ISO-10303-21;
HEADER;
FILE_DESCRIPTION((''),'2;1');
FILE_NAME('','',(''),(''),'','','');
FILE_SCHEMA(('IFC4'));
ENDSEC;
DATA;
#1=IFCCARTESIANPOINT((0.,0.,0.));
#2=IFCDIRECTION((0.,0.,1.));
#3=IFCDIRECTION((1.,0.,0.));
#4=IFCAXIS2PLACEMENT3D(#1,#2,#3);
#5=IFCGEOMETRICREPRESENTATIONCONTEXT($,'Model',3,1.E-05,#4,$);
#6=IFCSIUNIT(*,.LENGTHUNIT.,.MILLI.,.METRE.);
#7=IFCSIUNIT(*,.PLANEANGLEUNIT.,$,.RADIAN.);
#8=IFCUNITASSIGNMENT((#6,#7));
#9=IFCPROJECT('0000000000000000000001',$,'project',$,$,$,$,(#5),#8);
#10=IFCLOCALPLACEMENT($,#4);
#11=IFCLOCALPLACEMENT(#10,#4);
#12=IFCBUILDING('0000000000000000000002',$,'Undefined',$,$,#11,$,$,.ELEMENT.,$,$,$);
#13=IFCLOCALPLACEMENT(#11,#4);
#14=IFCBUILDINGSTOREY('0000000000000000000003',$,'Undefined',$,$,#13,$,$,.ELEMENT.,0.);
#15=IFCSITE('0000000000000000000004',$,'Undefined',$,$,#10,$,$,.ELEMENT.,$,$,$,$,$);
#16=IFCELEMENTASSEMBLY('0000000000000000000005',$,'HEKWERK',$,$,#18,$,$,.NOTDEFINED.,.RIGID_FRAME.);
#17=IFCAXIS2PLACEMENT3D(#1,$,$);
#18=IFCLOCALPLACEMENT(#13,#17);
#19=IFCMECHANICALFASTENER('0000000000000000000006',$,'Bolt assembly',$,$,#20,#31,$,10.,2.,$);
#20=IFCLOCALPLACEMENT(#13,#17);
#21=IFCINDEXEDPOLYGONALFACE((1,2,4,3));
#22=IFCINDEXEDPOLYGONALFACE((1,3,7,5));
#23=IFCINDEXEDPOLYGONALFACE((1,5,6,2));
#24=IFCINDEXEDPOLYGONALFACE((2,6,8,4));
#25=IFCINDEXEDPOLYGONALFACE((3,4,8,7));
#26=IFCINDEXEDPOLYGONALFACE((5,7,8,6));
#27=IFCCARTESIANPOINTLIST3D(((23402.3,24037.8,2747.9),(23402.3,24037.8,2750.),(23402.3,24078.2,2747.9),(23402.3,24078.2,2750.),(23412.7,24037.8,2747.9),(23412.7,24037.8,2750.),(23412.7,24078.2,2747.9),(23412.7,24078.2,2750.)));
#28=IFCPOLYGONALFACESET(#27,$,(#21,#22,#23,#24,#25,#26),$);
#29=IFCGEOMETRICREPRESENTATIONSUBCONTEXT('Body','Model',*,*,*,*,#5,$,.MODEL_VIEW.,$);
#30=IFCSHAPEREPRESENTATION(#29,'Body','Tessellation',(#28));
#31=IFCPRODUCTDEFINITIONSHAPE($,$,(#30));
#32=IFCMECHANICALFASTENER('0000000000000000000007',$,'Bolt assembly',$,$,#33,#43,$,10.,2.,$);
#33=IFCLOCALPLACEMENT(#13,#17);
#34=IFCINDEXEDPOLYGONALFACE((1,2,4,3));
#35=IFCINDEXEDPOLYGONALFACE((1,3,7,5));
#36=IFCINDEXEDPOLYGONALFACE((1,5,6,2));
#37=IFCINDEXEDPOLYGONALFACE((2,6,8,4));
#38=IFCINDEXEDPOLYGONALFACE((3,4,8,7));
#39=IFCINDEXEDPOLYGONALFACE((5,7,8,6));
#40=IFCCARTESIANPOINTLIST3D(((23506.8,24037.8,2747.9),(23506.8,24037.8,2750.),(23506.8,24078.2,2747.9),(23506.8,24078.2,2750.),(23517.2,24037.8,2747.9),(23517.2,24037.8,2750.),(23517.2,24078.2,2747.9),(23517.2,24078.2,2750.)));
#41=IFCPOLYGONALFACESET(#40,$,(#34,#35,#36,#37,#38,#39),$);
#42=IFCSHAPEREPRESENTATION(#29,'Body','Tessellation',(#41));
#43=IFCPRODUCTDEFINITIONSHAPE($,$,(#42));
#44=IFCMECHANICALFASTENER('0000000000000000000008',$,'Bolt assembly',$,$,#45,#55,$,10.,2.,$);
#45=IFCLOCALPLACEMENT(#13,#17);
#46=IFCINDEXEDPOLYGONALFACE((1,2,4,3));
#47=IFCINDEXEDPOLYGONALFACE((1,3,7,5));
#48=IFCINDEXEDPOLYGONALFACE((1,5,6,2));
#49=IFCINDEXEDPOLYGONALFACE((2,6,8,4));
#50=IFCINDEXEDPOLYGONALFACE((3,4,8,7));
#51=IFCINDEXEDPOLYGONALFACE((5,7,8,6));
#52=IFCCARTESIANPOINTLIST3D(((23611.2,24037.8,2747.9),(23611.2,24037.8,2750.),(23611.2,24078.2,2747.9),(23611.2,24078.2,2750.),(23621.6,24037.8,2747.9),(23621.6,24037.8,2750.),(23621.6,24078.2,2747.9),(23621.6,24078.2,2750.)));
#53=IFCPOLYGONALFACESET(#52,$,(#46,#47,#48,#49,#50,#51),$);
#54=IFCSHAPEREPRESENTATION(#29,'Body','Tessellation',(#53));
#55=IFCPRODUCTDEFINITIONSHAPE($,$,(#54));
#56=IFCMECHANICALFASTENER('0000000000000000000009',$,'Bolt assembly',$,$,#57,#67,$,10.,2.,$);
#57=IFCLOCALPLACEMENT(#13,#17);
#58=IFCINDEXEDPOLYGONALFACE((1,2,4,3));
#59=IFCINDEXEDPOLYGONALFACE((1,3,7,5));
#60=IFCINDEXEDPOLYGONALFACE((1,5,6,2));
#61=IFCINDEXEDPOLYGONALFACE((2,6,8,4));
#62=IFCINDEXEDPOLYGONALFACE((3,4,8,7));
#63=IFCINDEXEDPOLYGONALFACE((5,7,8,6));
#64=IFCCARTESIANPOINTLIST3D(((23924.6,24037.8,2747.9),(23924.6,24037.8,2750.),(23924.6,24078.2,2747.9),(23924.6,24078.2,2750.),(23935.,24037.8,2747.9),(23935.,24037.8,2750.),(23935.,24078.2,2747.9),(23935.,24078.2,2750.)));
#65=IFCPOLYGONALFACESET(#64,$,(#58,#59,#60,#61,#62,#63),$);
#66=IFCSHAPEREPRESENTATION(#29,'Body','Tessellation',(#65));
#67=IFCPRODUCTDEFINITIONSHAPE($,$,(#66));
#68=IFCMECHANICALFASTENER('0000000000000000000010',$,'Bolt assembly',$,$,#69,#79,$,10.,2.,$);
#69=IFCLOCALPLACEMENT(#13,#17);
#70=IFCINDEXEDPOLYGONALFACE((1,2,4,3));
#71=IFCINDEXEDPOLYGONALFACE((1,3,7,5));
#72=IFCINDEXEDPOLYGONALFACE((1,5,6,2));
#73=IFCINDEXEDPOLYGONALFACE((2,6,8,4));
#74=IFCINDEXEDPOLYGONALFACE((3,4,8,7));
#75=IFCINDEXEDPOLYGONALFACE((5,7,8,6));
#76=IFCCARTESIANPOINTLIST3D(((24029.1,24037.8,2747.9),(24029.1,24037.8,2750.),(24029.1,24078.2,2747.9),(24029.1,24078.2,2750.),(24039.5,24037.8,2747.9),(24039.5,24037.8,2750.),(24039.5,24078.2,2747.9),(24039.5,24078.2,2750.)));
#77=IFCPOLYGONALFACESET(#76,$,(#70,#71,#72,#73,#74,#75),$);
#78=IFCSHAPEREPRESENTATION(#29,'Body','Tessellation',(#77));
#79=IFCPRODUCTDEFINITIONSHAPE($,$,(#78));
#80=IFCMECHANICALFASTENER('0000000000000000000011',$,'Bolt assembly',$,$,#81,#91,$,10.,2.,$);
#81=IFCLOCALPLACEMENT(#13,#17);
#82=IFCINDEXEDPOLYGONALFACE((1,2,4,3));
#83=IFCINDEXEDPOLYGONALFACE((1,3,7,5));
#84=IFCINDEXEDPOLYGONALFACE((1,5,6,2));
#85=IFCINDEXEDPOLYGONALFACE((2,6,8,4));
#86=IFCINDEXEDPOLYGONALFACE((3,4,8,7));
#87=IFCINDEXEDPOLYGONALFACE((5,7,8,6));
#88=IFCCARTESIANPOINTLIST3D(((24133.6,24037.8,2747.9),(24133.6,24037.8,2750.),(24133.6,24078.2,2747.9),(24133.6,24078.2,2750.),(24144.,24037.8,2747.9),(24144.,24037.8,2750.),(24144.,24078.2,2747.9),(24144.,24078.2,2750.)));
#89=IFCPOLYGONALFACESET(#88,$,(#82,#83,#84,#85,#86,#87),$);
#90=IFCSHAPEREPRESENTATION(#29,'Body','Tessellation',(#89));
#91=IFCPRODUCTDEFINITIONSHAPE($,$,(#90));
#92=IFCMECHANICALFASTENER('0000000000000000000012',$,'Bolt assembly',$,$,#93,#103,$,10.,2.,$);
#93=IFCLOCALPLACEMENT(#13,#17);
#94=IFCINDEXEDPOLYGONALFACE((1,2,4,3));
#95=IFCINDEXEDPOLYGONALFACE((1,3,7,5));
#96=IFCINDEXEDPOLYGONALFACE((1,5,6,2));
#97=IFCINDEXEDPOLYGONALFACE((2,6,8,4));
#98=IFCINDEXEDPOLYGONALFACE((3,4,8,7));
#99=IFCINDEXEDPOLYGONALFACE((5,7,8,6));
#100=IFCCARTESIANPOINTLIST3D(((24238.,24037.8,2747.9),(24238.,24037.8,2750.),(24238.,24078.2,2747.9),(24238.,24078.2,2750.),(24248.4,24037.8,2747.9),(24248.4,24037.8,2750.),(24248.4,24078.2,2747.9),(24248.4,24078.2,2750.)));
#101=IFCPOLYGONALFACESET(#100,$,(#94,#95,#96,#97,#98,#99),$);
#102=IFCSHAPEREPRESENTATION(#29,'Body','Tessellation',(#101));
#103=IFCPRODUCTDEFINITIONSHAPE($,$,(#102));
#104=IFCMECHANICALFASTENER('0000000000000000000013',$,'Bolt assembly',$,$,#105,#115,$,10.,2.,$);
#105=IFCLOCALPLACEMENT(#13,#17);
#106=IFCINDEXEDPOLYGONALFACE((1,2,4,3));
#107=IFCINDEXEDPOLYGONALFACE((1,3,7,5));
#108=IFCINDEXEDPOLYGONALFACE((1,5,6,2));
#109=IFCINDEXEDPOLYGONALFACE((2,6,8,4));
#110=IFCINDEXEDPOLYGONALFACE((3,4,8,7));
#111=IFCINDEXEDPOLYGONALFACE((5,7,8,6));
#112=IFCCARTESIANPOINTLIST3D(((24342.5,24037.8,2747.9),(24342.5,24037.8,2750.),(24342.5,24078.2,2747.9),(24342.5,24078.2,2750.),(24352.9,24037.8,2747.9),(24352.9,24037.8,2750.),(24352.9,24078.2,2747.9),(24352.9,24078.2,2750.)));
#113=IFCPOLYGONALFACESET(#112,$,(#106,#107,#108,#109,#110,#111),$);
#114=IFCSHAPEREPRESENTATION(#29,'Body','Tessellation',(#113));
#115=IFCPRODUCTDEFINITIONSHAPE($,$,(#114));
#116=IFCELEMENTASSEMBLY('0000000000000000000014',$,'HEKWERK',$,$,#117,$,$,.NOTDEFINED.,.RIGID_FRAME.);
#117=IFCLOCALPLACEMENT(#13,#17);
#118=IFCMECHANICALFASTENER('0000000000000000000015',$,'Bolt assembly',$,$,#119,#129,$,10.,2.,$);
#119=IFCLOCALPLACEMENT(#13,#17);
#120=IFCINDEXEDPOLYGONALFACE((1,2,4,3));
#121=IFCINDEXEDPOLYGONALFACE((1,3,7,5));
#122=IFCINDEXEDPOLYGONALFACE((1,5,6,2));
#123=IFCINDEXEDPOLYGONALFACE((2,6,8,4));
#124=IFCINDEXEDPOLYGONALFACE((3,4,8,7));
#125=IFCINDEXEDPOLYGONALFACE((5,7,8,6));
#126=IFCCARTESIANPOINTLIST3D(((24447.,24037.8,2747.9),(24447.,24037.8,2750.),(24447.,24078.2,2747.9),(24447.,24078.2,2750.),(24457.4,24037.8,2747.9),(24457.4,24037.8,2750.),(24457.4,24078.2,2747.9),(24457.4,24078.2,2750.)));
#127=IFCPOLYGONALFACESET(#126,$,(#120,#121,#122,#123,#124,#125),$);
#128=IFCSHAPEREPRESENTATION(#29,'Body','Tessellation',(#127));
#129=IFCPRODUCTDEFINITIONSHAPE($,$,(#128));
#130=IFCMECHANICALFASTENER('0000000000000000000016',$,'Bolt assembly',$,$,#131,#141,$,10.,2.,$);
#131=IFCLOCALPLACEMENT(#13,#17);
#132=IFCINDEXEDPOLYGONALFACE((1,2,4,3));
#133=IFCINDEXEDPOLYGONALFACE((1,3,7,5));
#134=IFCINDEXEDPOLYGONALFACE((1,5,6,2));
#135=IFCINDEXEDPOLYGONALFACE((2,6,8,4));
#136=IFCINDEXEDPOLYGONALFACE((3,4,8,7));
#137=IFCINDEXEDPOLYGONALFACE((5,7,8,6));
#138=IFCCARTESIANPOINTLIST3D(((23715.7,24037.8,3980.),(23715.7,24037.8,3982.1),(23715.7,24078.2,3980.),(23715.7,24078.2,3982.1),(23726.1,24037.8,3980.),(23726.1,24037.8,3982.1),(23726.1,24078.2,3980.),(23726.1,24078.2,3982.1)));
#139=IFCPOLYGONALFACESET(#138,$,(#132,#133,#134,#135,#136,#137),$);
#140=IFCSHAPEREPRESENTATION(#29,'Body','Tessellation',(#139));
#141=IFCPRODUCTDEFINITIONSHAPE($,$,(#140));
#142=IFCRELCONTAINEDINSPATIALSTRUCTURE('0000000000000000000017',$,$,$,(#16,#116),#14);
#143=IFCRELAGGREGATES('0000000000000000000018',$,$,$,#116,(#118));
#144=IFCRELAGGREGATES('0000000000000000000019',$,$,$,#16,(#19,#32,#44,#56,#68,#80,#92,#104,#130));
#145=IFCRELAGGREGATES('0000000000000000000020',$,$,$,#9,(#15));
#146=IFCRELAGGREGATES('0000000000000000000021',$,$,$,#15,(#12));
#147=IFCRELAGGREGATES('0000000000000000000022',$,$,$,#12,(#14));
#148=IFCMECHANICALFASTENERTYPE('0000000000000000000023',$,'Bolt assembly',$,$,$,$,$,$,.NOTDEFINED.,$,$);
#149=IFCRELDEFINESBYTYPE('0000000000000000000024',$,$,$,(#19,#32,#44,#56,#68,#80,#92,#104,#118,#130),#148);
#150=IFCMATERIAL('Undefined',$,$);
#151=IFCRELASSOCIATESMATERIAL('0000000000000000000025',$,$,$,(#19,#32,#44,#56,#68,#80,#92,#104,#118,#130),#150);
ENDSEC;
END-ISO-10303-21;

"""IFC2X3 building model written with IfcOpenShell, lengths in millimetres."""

from ifc_helpers import new_model, si_unit, frame, origin_with_axes, place, context, subcontext, project, spatial, polyline, segment, composite_curve, outline, extrude, source, transform, mapped, material, type_object, element, aggregate, save


model = new_model("IFC2X3")

# Units and contexts
model_context = context("Model", 3, precision=1e-05, world=origin_with_axes())
body_context = subcontext(model_context, "Body", "Model", "MODEL_VIEW")
ifc_project = project(units=[si_unit("LENGTHUNIT", "METRE", prefix="MILLI"), si_unit("PLANEANGLEUNIT", "RADIAN")], contexts=[model_context])

# Site, building, storey
site_placement = place(None, origin_with_axes())
site = spatial("IfcSite", under=ifc_project, at=site_placement, Name="Undefined", CompositionType="ELEMENT")
building_placement = place(site_placement, origin_with_axes())
building = spatial("IfcBuilding", under=site, at=building_placement, Name="Undefined", CompositionType="ELEMENT")
storey_placement = place(building_placement, origin_with_axes())
storey = spatial("IfcBuildingStorey", under=building, at=storey_placement, Name="Undefined", CompositionType="ELEMENT", Elevation=0.0)

# Element assembly, mechanical fasteners
assembly_1_placement = place(storey_placement, origin_with_axes())
assembly_1 = element("IfcElementAssembly", 1, at=assembly_1_placement, inside=storey, Name="HEKWERK", AssemblyPlace="NOTDEFINED", PredefinedType="RIGID_FRAME")
ifc_material_1 = material(Name="Undefined")
mechanical_fastener_type = type_object("IfcMechanicalFastenerType", Name="Bolt assembly")
shared_shape_1 = source(origin_with_axes(), body_context, "Body", "SweptSolid", [
    extrude(outline(composite_curve([segment(polyline([(-20.2, 5.2), (20.2, 5.2)]), True, "CONTINUOUS"), segment(polyline([(20.2, 5.2), (20.2, -5.2)]), True, "CONTINUOUS"), segment(polyline([(20.2, -5.2), (-20.2, -5.2)]), True, "CONTINUOUS"), segment(polyline([(-20.2, -5.2), (-20.2, 5.2)]), True, "CONTINUOUS")], self_intersect=False)), frame((0.0, -1.0, 0.0), z_axis=(0.0, 1.0, 0.0), x_axis=(1.0, 0.0, 0.0)), (0.0, 0.0, 1.0), 2.1),
])
mechanical_fastener_1_placement = place(assembly_1_placement, frame((23407.5, 24058.0, 2749.0), z_axis=(-1.0, 0.0, 0.0), x_axis=(0.0, 1.0, 0.0)))
mechanical_fastener_1 = element("IfcMechanicalFastener", 2, at=mechanical_fastener_1_placement, type_object=mechanical_fastener_type, material=ifc_material_1, Name="Bolt assembly", NominalDiameter=10.0, NominalLength=2.0, context=body_context, shape_type="MappedRepresentation", body=[
    mapped(shared_shape_1, transform((0.0, 0.0, 0.0))),
])
shared_shape_2 = source(origin_with_axes(), body_context, "Body", "SweptSolid", [
    extrude(outline(composite_curve([segment(polyline([(-20.2, 5.2), (20.2, 5.2)]), True, "CONTINUOUS"), segment(polyline([(20.2, 5.2), (20.2, -5.2)]), True, "CONTINUOUS"), segment(polyline([(20.2, -5.2), (-20.2, -5.2)]), True, "CONTINUOUS"), segment(polyline([(-20.2, -5.2), (-20.2, 5.2)]), True, "CONTINUOUS")], self_intersect=False)), frame((0.0, -1.0, 0.0), z_axis=(0.0, 1.0, 0.0), x_axis=(1.0, 0.0, 0.0)), (0.0, 0.0, 1.0), 2.1),
])
mechanical_fastener_2_placement = place(assembly_1_placement, frame((23512.0, 24058.0, 2749.0), z_axis=(-1.0, 0.0, 0.0), x_axis=(0.0, 1.0, 0.0)))
mechanical_fastener_2 = element("IfcMechanicalFastener", 3, at=mechanical_fastener_2_placement, type_object=mechanical_fastener_type, material=ifc_material_1, Name="Bolt assembly", NominalDiameter=10.0, NominalLength=2.0, context=body_context, shape_type="MappedRepresentation", body=[
    mapped(shared_shape_2, transform((0.0, 0.0, 0.0))),
])
shared_shape_3 = source(origin_with_axes(), body_context, "Body", "SweptSolid", [
    extrude(outline(composite_curve([segment(polyline([(-20.2, 5.2), (20.2, 5.2)]), True, "CONTINUOUS"), segment(polyline([(20.2, 5.2), (20.2, -5.2)]), True, "CONTINUOUS"), segment(polyline([(20.2, -5.2), (-20.2, -5.2)]), True, "CONTINUOUS"), segment(polyline([(-20.2, -5.2), (-20.2, 5.2)]), True, "CONTINUOUS")], self_intersect=False)), frame((0.0, -1.0, 0.0), z_axis=(0.0, 1.0, 0.0), x_axis=(1.0, 0.0, 0.0)), (0.0, 0.0, 1.0), 2.1),
])
mechanical_fastener_3_placement = place(assembly_1_placement, frame((23616.4, 24058.0, 2749.0), z_axis=(-1.0, 0.0, 0.0), x_axis=(0.0, 1.0, 0.0)))
mechanical_fastener_3 = element("IfcMechanicalFastener", 4, at=mechanical_fastener_3_placement, type_object=mechanical_fastener_type, material=ifc_material_1, Name="Bolt assembly", NominalDiameter=10.0, NominalLength=2.0, context=body_context, shape_type="MappedRepresentation", body=[
    mapped(shared_shape_3, transform((0.0, 0.0, 0.0))),
])
shared_shape_4 = source(origin_with_axes(), body_context, "Body", "SweptSolid", [
    extrude(outline(composite_curve([segment(polyline([(-20.2, 5.2), (20.2, 5.2)]), True, "CONTINUOUS"), segment(polyline([(20.2, 5.2), (20.2, -5.2)]), True, "CONTINUOUS"), segment(polyline([(20.2, -5.2), (-20.2, -5.2)]), True, "CONTINUOUS"), segment(polyline([(-20.2, -5.2), (-20.2, 5.2)]), True, "CONTINUOUS")], self_intersect=False)), frame((0.0, -1.0, 0.0), z_axis=(0.0, 1.0, 0.0), x_axis=(1.0, 0.0, 0.0)), (0.0, 0.0, 1.0), 2.1),
])
mechanical_fastener_4_placement = place(assembly_1_placement, frame((23929.8, 24058.0, 2749.0), z_axis=(-1.0, 0.0, 0.0), x_axis=(0.0, 1.0, 0.0)))
mechanical_fastener_4 = element("IfcMechanicalFastener", 5, at=mechanical_fastener_4_placement, type_object=mechanical_fastener_type, material=ifc_material_1, Name="Bolt assembly", NominalDiameter=10.0, NominalLength=2.0, context=body_context, shape_type="MappedRepresentation", body=[
    mapped(shared_shape_4, transform((0.0, 0.0, 0.0))),
])
shared_shape_5 = source(origin_with_axes(), body_context, "Body", "SweptSolid", [
    extrude(outline(composite_curve([segment(polyline([(-20.2, 5.2), (20.2, 5.2)]), True, "CONTINUOUS"), segment(polyline([(20.2, 5.2), (20.2, -5.2)]), True, "CONTINUOUS"), segment(polyline([(20.2, -5.2), (-20.2, -5.2)]), True, "CONTINUOUS"), segment(polyline([(-20.2, -5.2), (-20.2, 5.2)]), True, "CONTINUOUS")], self_intersect=False)), frame((0.0, -1.0, 0.0), z_axis=(0.0, 1.0, 0.0), x_axis=(1.0, 0.0, 0.0)), (0.0, 0.0, 1.0), 2.1),
])
mechanical_fastener_5_placement = place(assembly_1_placement, frame((24034.3, 24058.0, 2749.0), z_axis=(-1.0, 0.0, 0.0), x_axis=(0.0, 1.0, 0.0)))
mechanical_fastener_5 = element("IfcMechanicalFastener", 6, at=mechanical_fastener_5_placement, type_object=mechanical_fastener_type, material=ifc_material_1, Name="Bolt assembly", NominalDiameter=10.0, NominalLength=2.0, context=body_context, shape_type="MappedRepresentation", body=[
    mapped(shared_shape_5, transform((0.0, 0.0, 0.0))),
])
shared_shape_6 = source(origin_with_axes(), body_context, "Body", "SweptSolid", [
    extrude(outline(composite_curve([segment(polyline([(-20.2, 5.2), (20.2, 5.2)]), True, "CONTINUOUS"), segment(polyline([(20.2, 5.2), (20.2, -5.2)]), True, "CONTINUOUS"), segment(polyline([(20.2, -5.2), (-20.2, -5.2)]), True, "CONTINUOUS"), segment(polyline([(-20.2, -5.2), (-20.2, 5.2)]), True, "CONTINUOUS")], self_intersect=False)), frame((0.0, -1.0, 0.0), z_axis=(0.0, 1.0, 0.0), x_axis=(1.0, 0.0, 0.0)), (0.0, 0.0, 1.0), 2.1),
])
mechanical_fastener_6_placement = place(assembly_1_placement, frame((24138.8, 24058.0, 2749.0), z_axis=(-1.0, 0.0, 0.0), x_axis=(0.0, 1.0, 0.0)))
mechanical_fastener_6 = element("IfcMechanicalFastener", 7, at=mechanical_fastener_6_placement, type_object=mechanical_fastener_type, material=ifc_material_1, Name="Bolt assembly", NominalDiameter=10.0, NominalLength=2.0, context=body_context, shape_type="MappedRepresentation", body=[
    mapped(shared_shape_6, transform((0.0, 0.0, 0.0))),
])
shared_shape_7 = source(origin_with_axes(), body_context, "Body", "SweptSolid", [
    extrude(outline(composite_curve([segment(polyline([(-20.2, 5.2), (20.2, 5.2)]), True, "CONTINUOUS"), segment(polyline([(20.2, 5.2), (20.2, -5.2)]), True, "CONTINUOUS"), segment(polyline([(20.2, -5.2), (-20.2, -5.2)]), True, "CONTINUOUS"), segment(polyline([(-20.2, -5.2), (-20.2, 5.2)]), True, "CONTINUOUS")], self_intersect=False)), frame((0.0, -1.0, 0.0), z_axis=(0.0, 1.0, 0.0), x_axis=(1.0, 0.0, 0.0)), (0.0, 0.0, 1.0), 2.1),
])
mechanical_fastener_7_placement = place(assembly_1_placement, frame((24243.2, 24058.0, 2749.0), z_axis=(-1.0, 0.0, 0.0), x_axis=(0.0, 1.0, 0.0)))
mechanical_fastener_7 = element("IfcMechanicalFastener", 8, at=mechanical_fastener_7_placement, type_object=mechanical_fastener_type, material=ifc_material_1, Name="Bolt assembly", NominalDiameter=10.0, NominalLength=2.0, context=body_context, shape_type="MappedRepresentation", body=[
    mapped(shared_shape_7, transform((0.0, 0.0, 0.0))),
])
shared_shape_8 = source(origin_with_axes(), body_context, "Body", "SweptSolid", [
    extrude(outline(composite_curve([segment(polyline([(-20.2, 5.2), (20.2, 5.2)]), True, "CONTINUOUS"), segment(polyline([(20.2, 5.2), (20.2, -5.2)]), True, "CONTINUOUS"), segment(polyline([(20.2, -5.2), (-20.2, -5.2)]), True, "CONTINUOUS"), segment(polyline([(-20.2, -5.2), (-20.2, 5.2)]), True, "CONTINUOUS")], self_intersect=False)), frame((0.0, -1.0, 0.0), z_axis=(0.0, 1.0, 0.0), x_axis=(1.0, 0.0, 0.0)), (0.0, 0.0, 1.0), 2.1),
])
mechanical_fastener_8_placement = place(assembly_1_placement, frame((24347.7, 24058.0, 2749.0), z_axis=(-1.0, 0.0, 0.0), x_axis=(0.0, 1.0, 0.0)))
mechanical_fastener_8 = element("IfcMechanicalFastener", 9, at=mechanical_fastener_8_placement, type_object=mechanical_fastener_type, material=ifc_material_1, Name="Bolt assembly", NominalDiameter=10.0, NominalLength=2.0, context=body_context, shape_type="MappedRepresentation", body=[
    mapped(shared_shape_8, transform((0.0, 0.0, 0.0))),
])

# Element assembly, mechanical fastener
assembly_2_placement = place(storey_placement, origin_with_axes())
assembly_2 = element("IfcElementAssembly", 10, at=assembly_2_placement, inside=storey, Name="HEKWERK", AssemblyPlace="NOTDEFINED", PredefinedType="RIGID_FRAME")
shared_shape_9 = source(origin_with_axes(), body_context, "Body", "SweptSolid", [
    extrude(outline(composite_curve([segment(polyline([(-20.2, 5.2), (20.2, 5.2)]), True, "CONTINUOUS"), segment(polyline([(20.2, 5.2), (20.2, -5.2)]), True, "CONTINUOUS"), segment(polyline([(20.2, -5.2), (-20.2, -5.2)]), True, "CONTINUOUS"), segment(polyline([(-20.2, -5.2), (-20.2, 5.2)]), True, "CONTINUOUS")], self_intersect=False)), frame((0.0, -1.0, 0.0), z_axis=(0.0, 1.0, 0.0), x_axis=(1.0, 0.0, 0.0)), (0.0, 0.0, 1.0), 2.1),
])
mechanical_fastener_9_placement = place(assembly_2_placement, frame((24452.2, 24058.0, 2749.0), z_axis=(-1.0, 0.0, 0.0), x_axis=(0.0, 1.0, 0.0)))
mechanical_fastener_9 = element("IfcMechanicalFastener", 11, at=mechanical_fastener_9_placement, type_object=mechanical_fastener_type, material=ifc_material_1, Name="Bolt assembly", NominalDiameter=10.0, NominalLength=2.0, context=body_context, shape_type="MappedRepresentation", body=[
    mapped(shared_shape_9, transform((0.0, 0.0, 0.0))),
])
aggregate(assembly_2, [mechanical_fastener_9])

# Mechanical fastener
shared_shape_10 = source(origin_with_axes(), body_context, "Body", "SweptSolid", [
    extrude(outline(composite_curve([segment(polyline([(-20.2, 5.2), (20.2, 5.2)]), True, "CONTINUOUS"), segment(polyline([(20.2, 5.2), (20.2, -5.2)]), True, "CONTINUOUS"), segment(polyline([(20.2, -5.2), (-20.2, -5.2)]), True, "CONTINUOUS"), segment(polyline([(-20.2, -5.2), (-20.2, 5.2)]), True, "CONTINUOUS")], self_intersect=False)), frame((0.0, -1.0, 0.0), z_axis=(0.0, 1.0, 0.0), x_axis=(1.0, 0.0, 0.0)), (0.0, 0.0, 1.0), 2.1),
])
mechanical_fastener_10_placement = place(assembly_1_placement, frame((23720.9, 24058.0, 3981.0), z_axis=(1.0, 0.0, 0.0), x_axis=(0.0, 1.0, 0.0)))
mechanical_fastener_10 = element("IfcMechanicalFastener", 12, at=mechanical_fastener_10_placement, type_object=mechanical_fastener_type, material=ifc_material_1, Name="Bolt assembly", NominalDiameter=10.0, NominalLength=2.0, context=body_context, shape_type="MappedRepresentation", body=[
    mapped(shared_shape_10, transform((0.0, 0.0, 0.0))),
])
aggregate(assembly_1, [mechanical_fastener_1, mechanical_fastener_2, mechanical_fastener_3, mechanical_fastener_4, mechanical_fastener_5, mechanical_fastener_6, mechanical_fastener_7, mechanical_fastener_8, mechanical_fastener_10])

save(model, "model.ifc")
